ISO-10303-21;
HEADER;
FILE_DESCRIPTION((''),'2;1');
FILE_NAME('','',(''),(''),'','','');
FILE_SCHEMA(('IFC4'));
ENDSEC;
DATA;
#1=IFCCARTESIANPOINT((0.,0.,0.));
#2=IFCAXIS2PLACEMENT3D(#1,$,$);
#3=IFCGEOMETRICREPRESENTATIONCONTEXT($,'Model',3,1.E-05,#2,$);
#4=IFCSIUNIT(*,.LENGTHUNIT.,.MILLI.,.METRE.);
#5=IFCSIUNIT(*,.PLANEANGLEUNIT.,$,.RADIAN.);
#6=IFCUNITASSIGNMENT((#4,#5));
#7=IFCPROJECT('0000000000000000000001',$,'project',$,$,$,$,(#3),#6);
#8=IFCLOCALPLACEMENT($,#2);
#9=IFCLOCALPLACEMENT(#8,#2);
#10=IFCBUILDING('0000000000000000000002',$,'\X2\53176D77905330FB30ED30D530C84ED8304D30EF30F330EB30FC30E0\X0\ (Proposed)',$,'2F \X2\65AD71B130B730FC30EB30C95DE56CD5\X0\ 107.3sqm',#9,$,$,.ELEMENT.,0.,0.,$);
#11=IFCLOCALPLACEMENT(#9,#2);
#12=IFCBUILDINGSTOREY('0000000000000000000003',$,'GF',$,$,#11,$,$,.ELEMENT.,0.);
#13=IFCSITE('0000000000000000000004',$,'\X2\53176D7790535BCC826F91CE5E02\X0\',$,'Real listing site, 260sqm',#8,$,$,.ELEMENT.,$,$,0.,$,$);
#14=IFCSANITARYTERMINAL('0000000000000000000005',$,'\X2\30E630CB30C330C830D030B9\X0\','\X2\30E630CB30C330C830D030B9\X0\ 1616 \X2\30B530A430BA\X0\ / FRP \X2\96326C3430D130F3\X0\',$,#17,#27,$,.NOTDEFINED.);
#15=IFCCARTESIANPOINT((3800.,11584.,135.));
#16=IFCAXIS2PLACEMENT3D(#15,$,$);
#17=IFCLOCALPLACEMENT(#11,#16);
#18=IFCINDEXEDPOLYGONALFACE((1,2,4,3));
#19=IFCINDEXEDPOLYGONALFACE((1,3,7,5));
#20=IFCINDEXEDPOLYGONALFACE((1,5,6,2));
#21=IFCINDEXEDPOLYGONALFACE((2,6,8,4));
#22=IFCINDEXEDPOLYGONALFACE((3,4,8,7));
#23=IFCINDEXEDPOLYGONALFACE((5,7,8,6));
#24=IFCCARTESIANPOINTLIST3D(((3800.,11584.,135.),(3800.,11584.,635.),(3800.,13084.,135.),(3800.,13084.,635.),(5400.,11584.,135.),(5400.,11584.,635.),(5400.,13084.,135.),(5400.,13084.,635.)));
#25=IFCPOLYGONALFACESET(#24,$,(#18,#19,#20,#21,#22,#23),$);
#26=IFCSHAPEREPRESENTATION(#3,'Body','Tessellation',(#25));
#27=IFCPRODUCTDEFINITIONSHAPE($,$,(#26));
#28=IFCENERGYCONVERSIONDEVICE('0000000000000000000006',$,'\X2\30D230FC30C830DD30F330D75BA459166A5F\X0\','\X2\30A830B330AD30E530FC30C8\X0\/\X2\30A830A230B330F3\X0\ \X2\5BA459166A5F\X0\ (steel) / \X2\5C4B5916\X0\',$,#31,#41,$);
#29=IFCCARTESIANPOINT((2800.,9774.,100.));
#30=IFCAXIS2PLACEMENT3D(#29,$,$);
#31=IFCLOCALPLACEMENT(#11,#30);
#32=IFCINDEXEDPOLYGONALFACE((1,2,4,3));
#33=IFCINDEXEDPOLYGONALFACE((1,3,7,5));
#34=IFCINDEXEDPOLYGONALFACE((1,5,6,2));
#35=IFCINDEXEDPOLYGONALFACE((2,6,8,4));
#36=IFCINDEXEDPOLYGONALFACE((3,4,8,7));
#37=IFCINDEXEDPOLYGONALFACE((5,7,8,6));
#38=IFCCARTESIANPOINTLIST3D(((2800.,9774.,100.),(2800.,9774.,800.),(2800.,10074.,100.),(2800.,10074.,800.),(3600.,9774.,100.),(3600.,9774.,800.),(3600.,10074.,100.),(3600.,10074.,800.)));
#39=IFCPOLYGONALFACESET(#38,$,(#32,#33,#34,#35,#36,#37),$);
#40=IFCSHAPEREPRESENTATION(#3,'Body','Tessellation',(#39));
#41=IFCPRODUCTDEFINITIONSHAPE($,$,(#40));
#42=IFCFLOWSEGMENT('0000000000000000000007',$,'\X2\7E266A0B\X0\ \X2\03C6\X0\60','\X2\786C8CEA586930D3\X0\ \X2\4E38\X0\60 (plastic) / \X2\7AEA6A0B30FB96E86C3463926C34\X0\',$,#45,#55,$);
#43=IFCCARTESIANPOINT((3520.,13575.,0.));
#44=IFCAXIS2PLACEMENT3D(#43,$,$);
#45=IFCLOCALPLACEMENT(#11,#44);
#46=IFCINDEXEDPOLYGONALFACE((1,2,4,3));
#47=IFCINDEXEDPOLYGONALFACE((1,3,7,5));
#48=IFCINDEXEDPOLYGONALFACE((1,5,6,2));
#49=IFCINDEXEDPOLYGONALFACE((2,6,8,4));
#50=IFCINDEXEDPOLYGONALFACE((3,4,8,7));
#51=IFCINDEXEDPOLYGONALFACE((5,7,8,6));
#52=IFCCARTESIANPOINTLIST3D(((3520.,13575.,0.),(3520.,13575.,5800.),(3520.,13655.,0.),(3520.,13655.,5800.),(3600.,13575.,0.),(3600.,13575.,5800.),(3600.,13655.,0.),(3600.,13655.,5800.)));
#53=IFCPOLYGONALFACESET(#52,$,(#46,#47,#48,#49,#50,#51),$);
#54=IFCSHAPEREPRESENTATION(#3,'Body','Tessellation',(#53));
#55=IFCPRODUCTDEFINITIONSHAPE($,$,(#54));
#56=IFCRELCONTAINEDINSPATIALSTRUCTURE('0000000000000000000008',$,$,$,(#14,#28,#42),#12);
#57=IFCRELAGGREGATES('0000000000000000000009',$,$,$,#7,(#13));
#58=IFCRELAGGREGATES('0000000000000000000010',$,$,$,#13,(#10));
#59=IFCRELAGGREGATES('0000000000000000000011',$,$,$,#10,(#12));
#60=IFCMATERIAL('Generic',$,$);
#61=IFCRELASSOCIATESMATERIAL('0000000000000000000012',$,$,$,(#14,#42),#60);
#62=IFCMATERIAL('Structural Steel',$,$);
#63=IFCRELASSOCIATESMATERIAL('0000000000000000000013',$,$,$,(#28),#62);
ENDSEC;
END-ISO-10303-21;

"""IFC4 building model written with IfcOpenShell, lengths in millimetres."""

from ifc_helpers import new_model, si_unit, frame, frame_2d, origin, place, context, project, spatial, rectangle, extrude, material, element, save


model = new_model("IFC4")

# Units and contexts
model_context = context("Model", 3, precision=1e-05, world=origin())
ifc_project = project(units=[si_unit("LENGTHUNIT", "METRE", prefix="MILLI"), si_unit("PLANEANGLEUNIT", "RADIAN")], contexts=[model_context])

# Site, building, storey
site_placement = place(None, origin())
site = spatial("IfcSite", under=ifc_project, at=site_placement, Name="北海道富良野市", ObjectType="Real listing site, 260sqm", CompositionType="ELEMENT", RefElevation=0.0)
building_placement = place(site_placement, origin())
building = spatial("IfcBuilding", under=site, at=building_placement, Name="北海道・ロフト付きワンルーム (Proposed)", ObjectType="2F 断熱シールド工法 107.3sqm", CompositionType="ELEMENT", ElevationOfRefHeight=0.0, ElevationOfTerrain=0.0)
storey_placement = place(building_placement, origin())
storey = spatial("IfcBuildingStorey", under=building, at=storey_placement, Name="GF", CompositionType="ELEMENT", Elevation=0.0)

# Shared definitions
ifc_material_1 = material(Name="Generic")

# Sanitary terminal
sanitary_terminal_placement = place(storey_placement, frame((3800.0, 11584.0, 135.0)))
element("IfcSanitaryTerminal", 1, at=sanitary_terminal_placement, inside=storey, material=ifc_material_1, Name="ユニットバス", Description="ユニットバス 1616 サイズ / FRP 防水パン", PredefinedType="NOTDEFINED", context=model_context, shape_type="SweptSolid", body=[
    extrude(rectangle(XDim=1600.0, YDim=1500.0, at=frame_2d((800.0, 750.0))), frame((3800.0, 11584.0, 135.0)), (0.0, 0.0, 1.0), 500.0),
])

# Energy conversion device
ifc_material_2 = material(Name="Structural Steel")
energy_conversion_device_placement = place(storey_placement, frame((2800.0, 9774.0, 100.0)))
element("IfcEnergyConversionDevice", 2, at=energy_conversion_device_placement, inside=storey, material=ifc_material_2, Name="ヒートポンプ室外機", Description="エコキュート/エアコン 室外機 (steel) / 屋外", context=model_context, shape_type="SweptSolid", body=[
    extrude(rectangle(XDim=800.0, YDim=300.0, at=frame_2d((400.0, 150.0))), frame((2800.0, 9774.0, 100.0)), (0.0, 0.0, 1.0), 700.0),
])

# Flow segment
flow_segment_placement = place(storey_placement, frame((3520.0, 13575.0, 0.0)))
element("IfcFlowSegment", 3, at=flow_segment_placement, inside=storey, material=ifc_material_1, Name="縦樋 φ60", Description="硬質塩ビ 丸60 (plastic) / 竪樋・雨水排水", context=model_context, shape_type="SweptSolid", body=[
    extrude(rectangle(XDim=80.0, YDim=80.0, at=frame_2d((40.0, 40.0))), frame((3520.0, 13575.0, 0.0)), (0.0, 0.0, 1.0), 5800.0),
])

save(model, "model.ifc")
